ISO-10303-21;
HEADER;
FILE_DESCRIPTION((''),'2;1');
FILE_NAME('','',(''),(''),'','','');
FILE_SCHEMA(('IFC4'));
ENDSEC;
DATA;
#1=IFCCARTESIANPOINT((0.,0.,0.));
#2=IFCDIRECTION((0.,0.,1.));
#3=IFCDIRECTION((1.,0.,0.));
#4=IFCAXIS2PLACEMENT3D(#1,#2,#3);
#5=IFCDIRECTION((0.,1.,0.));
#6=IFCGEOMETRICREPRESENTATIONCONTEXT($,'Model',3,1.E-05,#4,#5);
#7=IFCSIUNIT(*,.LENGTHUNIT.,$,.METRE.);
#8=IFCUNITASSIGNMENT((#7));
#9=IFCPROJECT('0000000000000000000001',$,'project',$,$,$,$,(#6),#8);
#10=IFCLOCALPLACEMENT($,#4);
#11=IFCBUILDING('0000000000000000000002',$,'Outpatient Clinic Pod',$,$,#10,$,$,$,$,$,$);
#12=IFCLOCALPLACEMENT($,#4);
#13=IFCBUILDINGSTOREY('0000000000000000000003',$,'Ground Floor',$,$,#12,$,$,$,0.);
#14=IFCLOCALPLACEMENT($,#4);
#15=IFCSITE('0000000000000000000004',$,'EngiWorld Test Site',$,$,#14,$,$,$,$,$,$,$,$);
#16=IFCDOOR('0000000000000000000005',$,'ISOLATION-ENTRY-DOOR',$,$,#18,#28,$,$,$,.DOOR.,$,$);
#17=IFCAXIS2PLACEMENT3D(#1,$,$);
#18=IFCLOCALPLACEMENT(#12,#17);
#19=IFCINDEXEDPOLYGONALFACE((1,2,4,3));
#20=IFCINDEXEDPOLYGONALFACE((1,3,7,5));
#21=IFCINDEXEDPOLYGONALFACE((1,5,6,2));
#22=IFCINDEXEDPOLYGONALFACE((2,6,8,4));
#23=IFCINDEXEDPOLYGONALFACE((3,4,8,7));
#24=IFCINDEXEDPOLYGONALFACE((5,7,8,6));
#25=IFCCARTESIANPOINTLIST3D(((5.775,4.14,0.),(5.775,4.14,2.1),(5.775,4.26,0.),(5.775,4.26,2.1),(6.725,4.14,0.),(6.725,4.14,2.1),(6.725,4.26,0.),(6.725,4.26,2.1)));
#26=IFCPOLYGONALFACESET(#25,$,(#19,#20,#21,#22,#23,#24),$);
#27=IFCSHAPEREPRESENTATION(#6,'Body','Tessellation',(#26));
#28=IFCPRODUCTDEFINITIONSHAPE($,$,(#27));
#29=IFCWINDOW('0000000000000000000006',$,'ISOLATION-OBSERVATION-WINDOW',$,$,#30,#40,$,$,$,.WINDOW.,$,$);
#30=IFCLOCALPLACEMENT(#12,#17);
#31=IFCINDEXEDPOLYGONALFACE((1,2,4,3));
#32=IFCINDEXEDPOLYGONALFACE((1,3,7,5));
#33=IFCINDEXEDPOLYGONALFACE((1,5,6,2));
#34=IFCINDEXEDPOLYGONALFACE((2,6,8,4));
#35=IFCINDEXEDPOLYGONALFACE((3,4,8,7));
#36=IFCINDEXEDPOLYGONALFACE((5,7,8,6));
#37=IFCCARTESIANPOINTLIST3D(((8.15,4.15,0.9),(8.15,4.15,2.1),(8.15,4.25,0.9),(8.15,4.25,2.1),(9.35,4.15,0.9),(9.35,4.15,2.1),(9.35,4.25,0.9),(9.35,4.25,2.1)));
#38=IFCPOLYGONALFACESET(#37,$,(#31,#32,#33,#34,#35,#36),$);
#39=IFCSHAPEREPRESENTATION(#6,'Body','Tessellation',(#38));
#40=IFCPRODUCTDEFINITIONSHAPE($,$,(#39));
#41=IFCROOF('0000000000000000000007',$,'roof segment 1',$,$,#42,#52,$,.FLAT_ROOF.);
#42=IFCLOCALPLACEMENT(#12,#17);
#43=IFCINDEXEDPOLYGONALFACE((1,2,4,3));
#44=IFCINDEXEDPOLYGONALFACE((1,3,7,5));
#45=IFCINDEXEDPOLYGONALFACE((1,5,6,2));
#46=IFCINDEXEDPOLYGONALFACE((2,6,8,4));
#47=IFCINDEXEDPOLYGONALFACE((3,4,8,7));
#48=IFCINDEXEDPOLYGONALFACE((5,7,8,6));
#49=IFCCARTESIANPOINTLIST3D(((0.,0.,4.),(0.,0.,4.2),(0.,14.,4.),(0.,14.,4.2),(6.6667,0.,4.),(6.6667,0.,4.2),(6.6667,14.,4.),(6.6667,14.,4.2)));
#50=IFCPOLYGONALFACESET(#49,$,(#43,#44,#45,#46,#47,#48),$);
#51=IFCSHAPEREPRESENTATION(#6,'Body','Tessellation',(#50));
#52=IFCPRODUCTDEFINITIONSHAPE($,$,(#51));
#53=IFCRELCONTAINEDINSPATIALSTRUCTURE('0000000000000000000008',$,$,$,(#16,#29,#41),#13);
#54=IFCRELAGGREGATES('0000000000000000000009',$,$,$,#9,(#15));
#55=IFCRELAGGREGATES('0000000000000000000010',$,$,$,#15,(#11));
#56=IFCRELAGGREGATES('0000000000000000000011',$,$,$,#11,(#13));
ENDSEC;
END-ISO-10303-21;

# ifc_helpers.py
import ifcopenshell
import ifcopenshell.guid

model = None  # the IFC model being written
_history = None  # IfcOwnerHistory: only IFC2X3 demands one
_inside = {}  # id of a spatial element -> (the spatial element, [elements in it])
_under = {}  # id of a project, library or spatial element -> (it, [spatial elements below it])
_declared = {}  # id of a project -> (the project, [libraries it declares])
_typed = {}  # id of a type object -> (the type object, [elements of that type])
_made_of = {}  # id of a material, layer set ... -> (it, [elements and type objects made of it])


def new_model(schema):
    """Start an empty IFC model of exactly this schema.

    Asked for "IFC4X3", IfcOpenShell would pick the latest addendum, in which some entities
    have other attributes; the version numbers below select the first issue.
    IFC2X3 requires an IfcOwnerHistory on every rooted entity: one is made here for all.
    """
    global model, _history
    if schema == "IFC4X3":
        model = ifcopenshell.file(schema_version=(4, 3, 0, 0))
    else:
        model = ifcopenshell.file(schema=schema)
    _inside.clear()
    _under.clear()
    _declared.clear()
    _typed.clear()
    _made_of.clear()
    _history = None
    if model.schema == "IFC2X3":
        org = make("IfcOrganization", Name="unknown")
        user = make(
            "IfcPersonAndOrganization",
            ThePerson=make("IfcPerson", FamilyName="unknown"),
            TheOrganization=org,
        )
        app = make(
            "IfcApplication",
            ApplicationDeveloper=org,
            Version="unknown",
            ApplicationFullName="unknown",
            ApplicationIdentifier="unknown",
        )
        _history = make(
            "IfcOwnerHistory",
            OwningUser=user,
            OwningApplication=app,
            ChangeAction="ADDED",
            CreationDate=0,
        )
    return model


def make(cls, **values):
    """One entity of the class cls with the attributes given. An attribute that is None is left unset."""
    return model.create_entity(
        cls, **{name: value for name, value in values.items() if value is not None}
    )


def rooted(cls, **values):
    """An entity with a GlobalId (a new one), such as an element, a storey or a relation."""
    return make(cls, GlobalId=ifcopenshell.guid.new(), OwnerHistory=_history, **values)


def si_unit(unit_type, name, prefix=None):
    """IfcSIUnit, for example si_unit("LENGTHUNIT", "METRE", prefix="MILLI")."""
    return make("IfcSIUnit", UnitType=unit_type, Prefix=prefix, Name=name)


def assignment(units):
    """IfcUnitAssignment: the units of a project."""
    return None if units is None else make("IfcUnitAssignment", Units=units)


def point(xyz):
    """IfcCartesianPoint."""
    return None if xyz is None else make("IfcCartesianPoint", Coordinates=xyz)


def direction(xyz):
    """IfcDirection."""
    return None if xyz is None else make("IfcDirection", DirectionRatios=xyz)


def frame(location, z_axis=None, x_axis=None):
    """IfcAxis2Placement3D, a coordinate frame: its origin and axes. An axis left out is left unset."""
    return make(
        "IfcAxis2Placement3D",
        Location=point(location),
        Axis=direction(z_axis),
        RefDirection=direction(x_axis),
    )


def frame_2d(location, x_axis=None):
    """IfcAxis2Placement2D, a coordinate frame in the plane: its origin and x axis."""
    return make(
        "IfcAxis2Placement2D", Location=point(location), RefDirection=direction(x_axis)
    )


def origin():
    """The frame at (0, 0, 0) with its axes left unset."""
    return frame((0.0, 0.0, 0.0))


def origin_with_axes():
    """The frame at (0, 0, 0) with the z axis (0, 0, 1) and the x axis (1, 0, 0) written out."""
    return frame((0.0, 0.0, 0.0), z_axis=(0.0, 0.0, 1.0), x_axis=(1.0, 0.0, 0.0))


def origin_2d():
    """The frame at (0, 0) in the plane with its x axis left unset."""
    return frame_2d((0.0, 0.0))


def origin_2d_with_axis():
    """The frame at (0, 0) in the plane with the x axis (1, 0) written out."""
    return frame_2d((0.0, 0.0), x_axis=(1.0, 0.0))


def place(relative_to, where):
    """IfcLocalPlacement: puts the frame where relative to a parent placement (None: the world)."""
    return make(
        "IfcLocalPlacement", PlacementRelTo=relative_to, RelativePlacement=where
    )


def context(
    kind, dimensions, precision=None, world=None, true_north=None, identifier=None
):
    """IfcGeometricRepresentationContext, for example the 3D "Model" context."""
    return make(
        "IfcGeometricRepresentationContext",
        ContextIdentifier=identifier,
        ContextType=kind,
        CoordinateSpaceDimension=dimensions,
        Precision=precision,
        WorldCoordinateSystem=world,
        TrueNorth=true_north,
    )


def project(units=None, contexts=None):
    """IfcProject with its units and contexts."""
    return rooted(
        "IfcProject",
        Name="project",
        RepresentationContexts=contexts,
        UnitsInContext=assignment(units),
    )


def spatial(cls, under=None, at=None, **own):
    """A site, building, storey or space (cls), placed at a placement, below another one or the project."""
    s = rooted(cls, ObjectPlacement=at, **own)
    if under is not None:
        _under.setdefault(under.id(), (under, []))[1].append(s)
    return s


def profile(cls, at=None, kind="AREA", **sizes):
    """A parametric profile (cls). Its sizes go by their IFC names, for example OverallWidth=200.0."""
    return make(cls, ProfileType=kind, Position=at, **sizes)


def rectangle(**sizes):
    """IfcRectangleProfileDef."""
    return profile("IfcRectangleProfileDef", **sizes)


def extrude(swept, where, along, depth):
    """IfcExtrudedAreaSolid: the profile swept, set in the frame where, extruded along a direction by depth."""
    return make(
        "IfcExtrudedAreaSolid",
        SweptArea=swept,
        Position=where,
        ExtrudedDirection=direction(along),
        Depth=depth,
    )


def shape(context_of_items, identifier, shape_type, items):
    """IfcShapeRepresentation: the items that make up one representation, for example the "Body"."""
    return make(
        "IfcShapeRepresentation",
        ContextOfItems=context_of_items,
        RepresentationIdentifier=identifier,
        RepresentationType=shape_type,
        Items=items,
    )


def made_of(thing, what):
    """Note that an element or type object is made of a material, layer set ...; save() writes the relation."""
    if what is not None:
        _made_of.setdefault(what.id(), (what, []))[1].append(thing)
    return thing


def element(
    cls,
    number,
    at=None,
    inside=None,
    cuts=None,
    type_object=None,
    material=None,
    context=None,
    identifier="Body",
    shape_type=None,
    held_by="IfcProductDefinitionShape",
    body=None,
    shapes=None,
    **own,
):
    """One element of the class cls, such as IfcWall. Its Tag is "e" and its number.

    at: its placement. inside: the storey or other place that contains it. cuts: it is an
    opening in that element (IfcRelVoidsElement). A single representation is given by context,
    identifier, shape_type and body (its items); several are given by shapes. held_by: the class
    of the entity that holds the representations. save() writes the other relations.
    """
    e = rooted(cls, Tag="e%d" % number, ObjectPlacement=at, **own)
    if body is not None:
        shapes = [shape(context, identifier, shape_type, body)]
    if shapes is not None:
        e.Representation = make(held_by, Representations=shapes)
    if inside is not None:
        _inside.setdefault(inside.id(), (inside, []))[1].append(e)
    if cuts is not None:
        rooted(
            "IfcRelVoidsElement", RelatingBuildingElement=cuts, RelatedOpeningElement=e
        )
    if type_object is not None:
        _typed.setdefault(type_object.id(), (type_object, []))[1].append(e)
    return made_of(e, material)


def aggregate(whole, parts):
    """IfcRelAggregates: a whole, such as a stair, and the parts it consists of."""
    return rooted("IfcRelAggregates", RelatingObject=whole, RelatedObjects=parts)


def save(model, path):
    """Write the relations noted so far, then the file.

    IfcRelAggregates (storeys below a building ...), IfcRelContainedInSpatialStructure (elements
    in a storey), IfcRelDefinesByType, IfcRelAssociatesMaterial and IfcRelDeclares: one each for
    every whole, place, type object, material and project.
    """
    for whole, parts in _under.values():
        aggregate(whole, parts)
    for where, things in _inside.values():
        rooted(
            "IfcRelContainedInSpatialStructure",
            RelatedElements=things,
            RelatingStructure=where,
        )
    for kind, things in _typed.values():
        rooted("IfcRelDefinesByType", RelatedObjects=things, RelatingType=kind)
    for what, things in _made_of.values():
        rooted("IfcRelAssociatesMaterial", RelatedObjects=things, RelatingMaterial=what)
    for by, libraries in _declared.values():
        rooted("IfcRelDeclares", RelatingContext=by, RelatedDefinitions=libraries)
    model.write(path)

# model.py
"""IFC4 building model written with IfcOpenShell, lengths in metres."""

from ifc_helpers import new_model, si_unit, direction, frame, origin, origin_with_axes, origin_2d, origin_2d_with_axis, place, context, project, spatial, rectangle, extrude, element, save


model = new_model("IFC4")

# Units and contexts
model_context = context("Model", 3, precision=1e-05, world=origin_with_axes(), true_north=direction((0.0, 1.0, 0.0)))
ifc_project = project(units=[si_unit("LENGTHUNIT", "METRE")], contexts=[model_context])

# Site, building, storey
site_placement = place(None, origin_with_axes())
site = spatial("IfcSite", under=ifc_project, at=site_placement, Name="EngiWorld Test Site")
building_placement = place(None, origin_with_axes())
building = spatial("IfcBuilding", under=site, at=building_placement, Name="Outpatient Clinic Pod")
storey_placement = place(None, origin_with_axes())
storey = spatial("IfcBuildingStorey", under=building, at=storey_placement, Name="Ground Floor", Elevation=0.0)

# Door
door_placement = place(None, frame((6.25, 4.2, 0.0)))
element("IfcDoor", 1, at=door_placement, inside=storey, Name="ISOLATION-ENTRY-DOOR", PredefinedType="DOOR", context=model_context, shape_type="SweptSolid", body=[
    extrude(rectangle(XDim=0.95, YDim=0.12, at=origin_2d()), origin(), (0.0, 0.0, 1.0), 2.1),
])

# Window
window_placement = place(None, frame((8.75, 4.2, 0.9)))
element("IfcWindow", 2, at=window_placement, inside=storey, Name="ISOLATION-OBSERVATION-WINDOW", PredefinedType="WINDOW", context=model_context, shape_type="SweptSolid", body=[
    extrude(rectangle(XDim=1.2, YDim=0.1, at=origin_2d()), origin(), (0.0, 0.0, 1.0), 1.2),
])

# Roof
roof_placement = place(None, frame((3.3333, 7.0, 4.0), z_axis=(0.0, 0.0, 1.0), x_axis=(1.0, 0.0, 0.0)))
element("IfcRoof", 3, at=roof_placement, inside=storey, Name="roof segment 1", PredefinedType="FLAT_ROOF", context=model_context, shape_type="SweptSolid", body=[
    extrude(rectangle(XDim=6.6667, YDim=14.0, at=origin_2d_with_axis()), origin_with_axes(), (0.0, 0.0, 1.0), 0.2),
])

save(model, "model.ifc")
